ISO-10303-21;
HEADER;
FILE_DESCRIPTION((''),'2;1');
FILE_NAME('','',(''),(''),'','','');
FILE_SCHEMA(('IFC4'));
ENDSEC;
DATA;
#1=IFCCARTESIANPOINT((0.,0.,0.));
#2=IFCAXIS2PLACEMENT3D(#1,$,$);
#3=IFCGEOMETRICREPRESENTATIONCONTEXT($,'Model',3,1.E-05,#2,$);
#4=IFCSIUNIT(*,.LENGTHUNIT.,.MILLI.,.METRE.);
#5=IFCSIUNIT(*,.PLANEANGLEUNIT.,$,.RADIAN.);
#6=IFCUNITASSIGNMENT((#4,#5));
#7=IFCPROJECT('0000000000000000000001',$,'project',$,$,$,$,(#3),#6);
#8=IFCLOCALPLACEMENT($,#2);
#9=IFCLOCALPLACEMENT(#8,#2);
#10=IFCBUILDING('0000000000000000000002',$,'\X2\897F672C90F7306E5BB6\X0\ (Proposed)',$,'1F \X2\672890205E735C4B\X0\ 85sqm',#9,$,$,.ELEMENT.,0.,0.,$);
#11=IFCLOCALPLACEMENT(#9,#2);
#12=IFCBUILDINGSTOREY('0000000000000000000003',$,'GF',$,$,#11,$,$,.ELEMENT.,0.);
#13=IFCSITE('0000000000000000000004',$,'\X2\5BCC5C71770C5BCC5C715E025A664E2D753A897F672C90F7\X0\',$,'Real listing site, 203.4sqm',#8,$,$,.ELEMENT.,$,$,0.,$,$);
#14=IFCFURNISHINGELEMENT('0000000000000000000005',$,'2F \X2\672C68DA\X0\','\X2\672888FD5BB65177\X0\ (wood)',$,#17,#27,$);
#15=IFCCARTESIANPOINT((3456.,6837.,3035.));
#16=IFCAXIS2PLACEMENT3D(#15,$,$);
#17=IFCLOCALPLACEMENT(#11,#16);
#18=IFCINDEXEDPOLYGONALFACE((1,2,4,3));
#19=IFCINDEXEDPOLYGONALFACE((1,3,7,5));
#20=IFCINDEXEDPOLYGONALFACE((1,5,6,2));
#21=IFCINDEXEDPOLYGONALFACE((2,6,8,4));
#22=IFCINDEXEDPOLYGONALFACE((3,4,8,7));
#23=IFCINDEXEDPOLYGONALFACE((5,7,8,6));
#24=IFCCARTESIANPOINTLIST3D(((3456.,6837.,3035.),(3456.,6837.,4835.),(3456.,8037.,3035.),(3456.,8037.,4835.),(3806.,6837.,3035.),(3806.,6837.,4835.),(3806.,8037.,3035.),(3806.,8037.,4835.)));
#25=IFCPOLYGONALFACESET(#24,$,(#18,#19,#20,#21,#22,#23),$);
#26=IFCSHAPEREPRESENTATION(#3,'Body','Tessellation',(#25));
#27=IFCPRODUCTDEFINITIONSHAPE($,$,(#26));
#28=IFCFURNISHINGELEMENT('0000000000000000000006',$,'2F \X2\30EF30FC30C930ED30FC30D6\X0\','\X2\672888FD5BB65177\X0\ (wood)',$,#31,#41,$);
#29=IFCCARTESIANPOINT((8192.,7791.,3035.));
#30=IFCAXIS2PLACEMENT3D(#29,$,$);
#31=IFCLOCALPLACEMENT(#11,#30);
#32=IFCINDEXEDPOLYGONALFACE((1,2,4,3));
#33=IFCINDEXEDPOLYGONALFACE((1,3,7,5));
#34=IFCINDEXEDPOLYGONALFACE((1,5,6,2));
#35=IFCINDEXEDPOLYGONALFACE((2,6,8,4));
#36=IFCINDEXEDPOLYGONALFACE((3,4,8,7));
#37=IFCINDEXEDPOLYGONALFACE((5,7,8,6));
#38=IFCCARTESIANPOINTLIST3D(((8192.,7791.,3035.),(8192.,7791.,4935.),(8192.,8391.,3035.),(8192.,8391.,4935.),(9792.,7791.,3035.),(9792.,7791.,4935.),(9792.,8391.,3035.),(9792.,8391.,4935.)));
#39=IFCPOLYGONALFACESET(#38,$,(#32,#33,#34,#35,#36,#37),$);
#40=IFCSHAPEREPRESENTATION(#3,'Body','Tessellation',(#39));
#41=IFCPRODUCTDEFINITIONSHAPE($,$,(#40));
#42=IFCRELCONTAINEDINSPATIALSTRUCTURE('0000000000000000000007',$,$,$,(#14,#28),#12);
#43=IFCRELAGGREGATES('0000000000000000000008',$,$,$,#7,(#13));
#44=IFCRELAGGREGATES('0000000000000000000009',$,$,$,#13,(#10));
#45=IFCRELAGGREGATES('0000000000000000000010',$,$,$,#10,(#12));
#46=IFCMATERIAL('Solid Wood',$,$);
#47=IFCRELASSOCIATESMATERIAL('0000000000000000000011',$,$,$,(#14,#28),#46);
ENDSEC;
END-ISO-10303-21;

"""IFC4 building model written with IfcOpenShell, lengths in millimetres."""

from ifc_helpers import new_model, si_unit, frame, frame_2d, origin, place, context, project, spatial, rectangle, extrude, material, element, save


model = new_model("IFC4")

# Units and contexts
model_context = context("Model", 3, precision=1e-05, world=origin())
ifc_project = project(units=[si_unit("LENGTHUNIT", "METRE", prefix="MILLI"), si_unit("PLANEANGLEUNIT", "RADIAN")], contexts=[model_context])

# Site, building, storey
site_placement = place(None, origin())
site = spatial("IfcSite", under=ifc_project, at=site_placement, Name="富山県富山市婦中町西本郷", ObjectType="Real listing site, 203.4sqm", CompositionType="ELEMENT", RefElevation=0.0)
building_placement = place(site_placement, origin())
building = spatial("IfcBuilding", under=site, at=building_placement, Name="西本郷の家 (Proposed)", ObjectType="1F 木造平屋 85sqm", CompositionType="ELEMENT", ElevationOfRefHeight=0.0, ElevationOfTerrain=0.0)
storey_placement = place(building_placement, origin())
storey = spatial("IfcBuildingStorey", under=building, at=storey_placement, Name="GF", CompositionType="ELEMENT", Elevation=0.0)

# Shared definitions
ifc_material_1 = material(Name="Solid Wood")

# Furnishing elements
furnishing_1_placement = place(storey_placement, frame((3456.0, 6837.0, 3035.0)))
element("IfcFurnishingElement", 1, at=furnishing_1_placement, inside=storey, material=ifc_material_1, Name="2F 本棚", Description="木製家具 (wood)", context=model_context, shape_type="SweptSolid", body=[
    extrude(rectangle(XDim=350.0, YDim=1200.0, at=frame_2d((175.0, 600.0))), frame((3456.0, 6837.0, 3035.0)), (0.0, 0.0, 1.0), 1800.0),
])
furnishing_2_placement = place(storey_placement, frame((8192.0, 7791.0, 3035.0)))
element("IfcFurnishingElement", 2, at=furnishing_2_placement, inside=storey, material=ifc_material_1, Name="2F ワードローブ", Description="木製家具 (wood)", context=model_context, shape_type="SweptSolid", body=[
    extrude(rectangle(XDim=1600.0, YDim=600.0, at=frame_2d((800.0, 300.0))), frame((8192.0, 7791.0, 3035.0)), (0.0, 0.0, 1.0), 1900.0),
])

save(model, "model.ifc")
